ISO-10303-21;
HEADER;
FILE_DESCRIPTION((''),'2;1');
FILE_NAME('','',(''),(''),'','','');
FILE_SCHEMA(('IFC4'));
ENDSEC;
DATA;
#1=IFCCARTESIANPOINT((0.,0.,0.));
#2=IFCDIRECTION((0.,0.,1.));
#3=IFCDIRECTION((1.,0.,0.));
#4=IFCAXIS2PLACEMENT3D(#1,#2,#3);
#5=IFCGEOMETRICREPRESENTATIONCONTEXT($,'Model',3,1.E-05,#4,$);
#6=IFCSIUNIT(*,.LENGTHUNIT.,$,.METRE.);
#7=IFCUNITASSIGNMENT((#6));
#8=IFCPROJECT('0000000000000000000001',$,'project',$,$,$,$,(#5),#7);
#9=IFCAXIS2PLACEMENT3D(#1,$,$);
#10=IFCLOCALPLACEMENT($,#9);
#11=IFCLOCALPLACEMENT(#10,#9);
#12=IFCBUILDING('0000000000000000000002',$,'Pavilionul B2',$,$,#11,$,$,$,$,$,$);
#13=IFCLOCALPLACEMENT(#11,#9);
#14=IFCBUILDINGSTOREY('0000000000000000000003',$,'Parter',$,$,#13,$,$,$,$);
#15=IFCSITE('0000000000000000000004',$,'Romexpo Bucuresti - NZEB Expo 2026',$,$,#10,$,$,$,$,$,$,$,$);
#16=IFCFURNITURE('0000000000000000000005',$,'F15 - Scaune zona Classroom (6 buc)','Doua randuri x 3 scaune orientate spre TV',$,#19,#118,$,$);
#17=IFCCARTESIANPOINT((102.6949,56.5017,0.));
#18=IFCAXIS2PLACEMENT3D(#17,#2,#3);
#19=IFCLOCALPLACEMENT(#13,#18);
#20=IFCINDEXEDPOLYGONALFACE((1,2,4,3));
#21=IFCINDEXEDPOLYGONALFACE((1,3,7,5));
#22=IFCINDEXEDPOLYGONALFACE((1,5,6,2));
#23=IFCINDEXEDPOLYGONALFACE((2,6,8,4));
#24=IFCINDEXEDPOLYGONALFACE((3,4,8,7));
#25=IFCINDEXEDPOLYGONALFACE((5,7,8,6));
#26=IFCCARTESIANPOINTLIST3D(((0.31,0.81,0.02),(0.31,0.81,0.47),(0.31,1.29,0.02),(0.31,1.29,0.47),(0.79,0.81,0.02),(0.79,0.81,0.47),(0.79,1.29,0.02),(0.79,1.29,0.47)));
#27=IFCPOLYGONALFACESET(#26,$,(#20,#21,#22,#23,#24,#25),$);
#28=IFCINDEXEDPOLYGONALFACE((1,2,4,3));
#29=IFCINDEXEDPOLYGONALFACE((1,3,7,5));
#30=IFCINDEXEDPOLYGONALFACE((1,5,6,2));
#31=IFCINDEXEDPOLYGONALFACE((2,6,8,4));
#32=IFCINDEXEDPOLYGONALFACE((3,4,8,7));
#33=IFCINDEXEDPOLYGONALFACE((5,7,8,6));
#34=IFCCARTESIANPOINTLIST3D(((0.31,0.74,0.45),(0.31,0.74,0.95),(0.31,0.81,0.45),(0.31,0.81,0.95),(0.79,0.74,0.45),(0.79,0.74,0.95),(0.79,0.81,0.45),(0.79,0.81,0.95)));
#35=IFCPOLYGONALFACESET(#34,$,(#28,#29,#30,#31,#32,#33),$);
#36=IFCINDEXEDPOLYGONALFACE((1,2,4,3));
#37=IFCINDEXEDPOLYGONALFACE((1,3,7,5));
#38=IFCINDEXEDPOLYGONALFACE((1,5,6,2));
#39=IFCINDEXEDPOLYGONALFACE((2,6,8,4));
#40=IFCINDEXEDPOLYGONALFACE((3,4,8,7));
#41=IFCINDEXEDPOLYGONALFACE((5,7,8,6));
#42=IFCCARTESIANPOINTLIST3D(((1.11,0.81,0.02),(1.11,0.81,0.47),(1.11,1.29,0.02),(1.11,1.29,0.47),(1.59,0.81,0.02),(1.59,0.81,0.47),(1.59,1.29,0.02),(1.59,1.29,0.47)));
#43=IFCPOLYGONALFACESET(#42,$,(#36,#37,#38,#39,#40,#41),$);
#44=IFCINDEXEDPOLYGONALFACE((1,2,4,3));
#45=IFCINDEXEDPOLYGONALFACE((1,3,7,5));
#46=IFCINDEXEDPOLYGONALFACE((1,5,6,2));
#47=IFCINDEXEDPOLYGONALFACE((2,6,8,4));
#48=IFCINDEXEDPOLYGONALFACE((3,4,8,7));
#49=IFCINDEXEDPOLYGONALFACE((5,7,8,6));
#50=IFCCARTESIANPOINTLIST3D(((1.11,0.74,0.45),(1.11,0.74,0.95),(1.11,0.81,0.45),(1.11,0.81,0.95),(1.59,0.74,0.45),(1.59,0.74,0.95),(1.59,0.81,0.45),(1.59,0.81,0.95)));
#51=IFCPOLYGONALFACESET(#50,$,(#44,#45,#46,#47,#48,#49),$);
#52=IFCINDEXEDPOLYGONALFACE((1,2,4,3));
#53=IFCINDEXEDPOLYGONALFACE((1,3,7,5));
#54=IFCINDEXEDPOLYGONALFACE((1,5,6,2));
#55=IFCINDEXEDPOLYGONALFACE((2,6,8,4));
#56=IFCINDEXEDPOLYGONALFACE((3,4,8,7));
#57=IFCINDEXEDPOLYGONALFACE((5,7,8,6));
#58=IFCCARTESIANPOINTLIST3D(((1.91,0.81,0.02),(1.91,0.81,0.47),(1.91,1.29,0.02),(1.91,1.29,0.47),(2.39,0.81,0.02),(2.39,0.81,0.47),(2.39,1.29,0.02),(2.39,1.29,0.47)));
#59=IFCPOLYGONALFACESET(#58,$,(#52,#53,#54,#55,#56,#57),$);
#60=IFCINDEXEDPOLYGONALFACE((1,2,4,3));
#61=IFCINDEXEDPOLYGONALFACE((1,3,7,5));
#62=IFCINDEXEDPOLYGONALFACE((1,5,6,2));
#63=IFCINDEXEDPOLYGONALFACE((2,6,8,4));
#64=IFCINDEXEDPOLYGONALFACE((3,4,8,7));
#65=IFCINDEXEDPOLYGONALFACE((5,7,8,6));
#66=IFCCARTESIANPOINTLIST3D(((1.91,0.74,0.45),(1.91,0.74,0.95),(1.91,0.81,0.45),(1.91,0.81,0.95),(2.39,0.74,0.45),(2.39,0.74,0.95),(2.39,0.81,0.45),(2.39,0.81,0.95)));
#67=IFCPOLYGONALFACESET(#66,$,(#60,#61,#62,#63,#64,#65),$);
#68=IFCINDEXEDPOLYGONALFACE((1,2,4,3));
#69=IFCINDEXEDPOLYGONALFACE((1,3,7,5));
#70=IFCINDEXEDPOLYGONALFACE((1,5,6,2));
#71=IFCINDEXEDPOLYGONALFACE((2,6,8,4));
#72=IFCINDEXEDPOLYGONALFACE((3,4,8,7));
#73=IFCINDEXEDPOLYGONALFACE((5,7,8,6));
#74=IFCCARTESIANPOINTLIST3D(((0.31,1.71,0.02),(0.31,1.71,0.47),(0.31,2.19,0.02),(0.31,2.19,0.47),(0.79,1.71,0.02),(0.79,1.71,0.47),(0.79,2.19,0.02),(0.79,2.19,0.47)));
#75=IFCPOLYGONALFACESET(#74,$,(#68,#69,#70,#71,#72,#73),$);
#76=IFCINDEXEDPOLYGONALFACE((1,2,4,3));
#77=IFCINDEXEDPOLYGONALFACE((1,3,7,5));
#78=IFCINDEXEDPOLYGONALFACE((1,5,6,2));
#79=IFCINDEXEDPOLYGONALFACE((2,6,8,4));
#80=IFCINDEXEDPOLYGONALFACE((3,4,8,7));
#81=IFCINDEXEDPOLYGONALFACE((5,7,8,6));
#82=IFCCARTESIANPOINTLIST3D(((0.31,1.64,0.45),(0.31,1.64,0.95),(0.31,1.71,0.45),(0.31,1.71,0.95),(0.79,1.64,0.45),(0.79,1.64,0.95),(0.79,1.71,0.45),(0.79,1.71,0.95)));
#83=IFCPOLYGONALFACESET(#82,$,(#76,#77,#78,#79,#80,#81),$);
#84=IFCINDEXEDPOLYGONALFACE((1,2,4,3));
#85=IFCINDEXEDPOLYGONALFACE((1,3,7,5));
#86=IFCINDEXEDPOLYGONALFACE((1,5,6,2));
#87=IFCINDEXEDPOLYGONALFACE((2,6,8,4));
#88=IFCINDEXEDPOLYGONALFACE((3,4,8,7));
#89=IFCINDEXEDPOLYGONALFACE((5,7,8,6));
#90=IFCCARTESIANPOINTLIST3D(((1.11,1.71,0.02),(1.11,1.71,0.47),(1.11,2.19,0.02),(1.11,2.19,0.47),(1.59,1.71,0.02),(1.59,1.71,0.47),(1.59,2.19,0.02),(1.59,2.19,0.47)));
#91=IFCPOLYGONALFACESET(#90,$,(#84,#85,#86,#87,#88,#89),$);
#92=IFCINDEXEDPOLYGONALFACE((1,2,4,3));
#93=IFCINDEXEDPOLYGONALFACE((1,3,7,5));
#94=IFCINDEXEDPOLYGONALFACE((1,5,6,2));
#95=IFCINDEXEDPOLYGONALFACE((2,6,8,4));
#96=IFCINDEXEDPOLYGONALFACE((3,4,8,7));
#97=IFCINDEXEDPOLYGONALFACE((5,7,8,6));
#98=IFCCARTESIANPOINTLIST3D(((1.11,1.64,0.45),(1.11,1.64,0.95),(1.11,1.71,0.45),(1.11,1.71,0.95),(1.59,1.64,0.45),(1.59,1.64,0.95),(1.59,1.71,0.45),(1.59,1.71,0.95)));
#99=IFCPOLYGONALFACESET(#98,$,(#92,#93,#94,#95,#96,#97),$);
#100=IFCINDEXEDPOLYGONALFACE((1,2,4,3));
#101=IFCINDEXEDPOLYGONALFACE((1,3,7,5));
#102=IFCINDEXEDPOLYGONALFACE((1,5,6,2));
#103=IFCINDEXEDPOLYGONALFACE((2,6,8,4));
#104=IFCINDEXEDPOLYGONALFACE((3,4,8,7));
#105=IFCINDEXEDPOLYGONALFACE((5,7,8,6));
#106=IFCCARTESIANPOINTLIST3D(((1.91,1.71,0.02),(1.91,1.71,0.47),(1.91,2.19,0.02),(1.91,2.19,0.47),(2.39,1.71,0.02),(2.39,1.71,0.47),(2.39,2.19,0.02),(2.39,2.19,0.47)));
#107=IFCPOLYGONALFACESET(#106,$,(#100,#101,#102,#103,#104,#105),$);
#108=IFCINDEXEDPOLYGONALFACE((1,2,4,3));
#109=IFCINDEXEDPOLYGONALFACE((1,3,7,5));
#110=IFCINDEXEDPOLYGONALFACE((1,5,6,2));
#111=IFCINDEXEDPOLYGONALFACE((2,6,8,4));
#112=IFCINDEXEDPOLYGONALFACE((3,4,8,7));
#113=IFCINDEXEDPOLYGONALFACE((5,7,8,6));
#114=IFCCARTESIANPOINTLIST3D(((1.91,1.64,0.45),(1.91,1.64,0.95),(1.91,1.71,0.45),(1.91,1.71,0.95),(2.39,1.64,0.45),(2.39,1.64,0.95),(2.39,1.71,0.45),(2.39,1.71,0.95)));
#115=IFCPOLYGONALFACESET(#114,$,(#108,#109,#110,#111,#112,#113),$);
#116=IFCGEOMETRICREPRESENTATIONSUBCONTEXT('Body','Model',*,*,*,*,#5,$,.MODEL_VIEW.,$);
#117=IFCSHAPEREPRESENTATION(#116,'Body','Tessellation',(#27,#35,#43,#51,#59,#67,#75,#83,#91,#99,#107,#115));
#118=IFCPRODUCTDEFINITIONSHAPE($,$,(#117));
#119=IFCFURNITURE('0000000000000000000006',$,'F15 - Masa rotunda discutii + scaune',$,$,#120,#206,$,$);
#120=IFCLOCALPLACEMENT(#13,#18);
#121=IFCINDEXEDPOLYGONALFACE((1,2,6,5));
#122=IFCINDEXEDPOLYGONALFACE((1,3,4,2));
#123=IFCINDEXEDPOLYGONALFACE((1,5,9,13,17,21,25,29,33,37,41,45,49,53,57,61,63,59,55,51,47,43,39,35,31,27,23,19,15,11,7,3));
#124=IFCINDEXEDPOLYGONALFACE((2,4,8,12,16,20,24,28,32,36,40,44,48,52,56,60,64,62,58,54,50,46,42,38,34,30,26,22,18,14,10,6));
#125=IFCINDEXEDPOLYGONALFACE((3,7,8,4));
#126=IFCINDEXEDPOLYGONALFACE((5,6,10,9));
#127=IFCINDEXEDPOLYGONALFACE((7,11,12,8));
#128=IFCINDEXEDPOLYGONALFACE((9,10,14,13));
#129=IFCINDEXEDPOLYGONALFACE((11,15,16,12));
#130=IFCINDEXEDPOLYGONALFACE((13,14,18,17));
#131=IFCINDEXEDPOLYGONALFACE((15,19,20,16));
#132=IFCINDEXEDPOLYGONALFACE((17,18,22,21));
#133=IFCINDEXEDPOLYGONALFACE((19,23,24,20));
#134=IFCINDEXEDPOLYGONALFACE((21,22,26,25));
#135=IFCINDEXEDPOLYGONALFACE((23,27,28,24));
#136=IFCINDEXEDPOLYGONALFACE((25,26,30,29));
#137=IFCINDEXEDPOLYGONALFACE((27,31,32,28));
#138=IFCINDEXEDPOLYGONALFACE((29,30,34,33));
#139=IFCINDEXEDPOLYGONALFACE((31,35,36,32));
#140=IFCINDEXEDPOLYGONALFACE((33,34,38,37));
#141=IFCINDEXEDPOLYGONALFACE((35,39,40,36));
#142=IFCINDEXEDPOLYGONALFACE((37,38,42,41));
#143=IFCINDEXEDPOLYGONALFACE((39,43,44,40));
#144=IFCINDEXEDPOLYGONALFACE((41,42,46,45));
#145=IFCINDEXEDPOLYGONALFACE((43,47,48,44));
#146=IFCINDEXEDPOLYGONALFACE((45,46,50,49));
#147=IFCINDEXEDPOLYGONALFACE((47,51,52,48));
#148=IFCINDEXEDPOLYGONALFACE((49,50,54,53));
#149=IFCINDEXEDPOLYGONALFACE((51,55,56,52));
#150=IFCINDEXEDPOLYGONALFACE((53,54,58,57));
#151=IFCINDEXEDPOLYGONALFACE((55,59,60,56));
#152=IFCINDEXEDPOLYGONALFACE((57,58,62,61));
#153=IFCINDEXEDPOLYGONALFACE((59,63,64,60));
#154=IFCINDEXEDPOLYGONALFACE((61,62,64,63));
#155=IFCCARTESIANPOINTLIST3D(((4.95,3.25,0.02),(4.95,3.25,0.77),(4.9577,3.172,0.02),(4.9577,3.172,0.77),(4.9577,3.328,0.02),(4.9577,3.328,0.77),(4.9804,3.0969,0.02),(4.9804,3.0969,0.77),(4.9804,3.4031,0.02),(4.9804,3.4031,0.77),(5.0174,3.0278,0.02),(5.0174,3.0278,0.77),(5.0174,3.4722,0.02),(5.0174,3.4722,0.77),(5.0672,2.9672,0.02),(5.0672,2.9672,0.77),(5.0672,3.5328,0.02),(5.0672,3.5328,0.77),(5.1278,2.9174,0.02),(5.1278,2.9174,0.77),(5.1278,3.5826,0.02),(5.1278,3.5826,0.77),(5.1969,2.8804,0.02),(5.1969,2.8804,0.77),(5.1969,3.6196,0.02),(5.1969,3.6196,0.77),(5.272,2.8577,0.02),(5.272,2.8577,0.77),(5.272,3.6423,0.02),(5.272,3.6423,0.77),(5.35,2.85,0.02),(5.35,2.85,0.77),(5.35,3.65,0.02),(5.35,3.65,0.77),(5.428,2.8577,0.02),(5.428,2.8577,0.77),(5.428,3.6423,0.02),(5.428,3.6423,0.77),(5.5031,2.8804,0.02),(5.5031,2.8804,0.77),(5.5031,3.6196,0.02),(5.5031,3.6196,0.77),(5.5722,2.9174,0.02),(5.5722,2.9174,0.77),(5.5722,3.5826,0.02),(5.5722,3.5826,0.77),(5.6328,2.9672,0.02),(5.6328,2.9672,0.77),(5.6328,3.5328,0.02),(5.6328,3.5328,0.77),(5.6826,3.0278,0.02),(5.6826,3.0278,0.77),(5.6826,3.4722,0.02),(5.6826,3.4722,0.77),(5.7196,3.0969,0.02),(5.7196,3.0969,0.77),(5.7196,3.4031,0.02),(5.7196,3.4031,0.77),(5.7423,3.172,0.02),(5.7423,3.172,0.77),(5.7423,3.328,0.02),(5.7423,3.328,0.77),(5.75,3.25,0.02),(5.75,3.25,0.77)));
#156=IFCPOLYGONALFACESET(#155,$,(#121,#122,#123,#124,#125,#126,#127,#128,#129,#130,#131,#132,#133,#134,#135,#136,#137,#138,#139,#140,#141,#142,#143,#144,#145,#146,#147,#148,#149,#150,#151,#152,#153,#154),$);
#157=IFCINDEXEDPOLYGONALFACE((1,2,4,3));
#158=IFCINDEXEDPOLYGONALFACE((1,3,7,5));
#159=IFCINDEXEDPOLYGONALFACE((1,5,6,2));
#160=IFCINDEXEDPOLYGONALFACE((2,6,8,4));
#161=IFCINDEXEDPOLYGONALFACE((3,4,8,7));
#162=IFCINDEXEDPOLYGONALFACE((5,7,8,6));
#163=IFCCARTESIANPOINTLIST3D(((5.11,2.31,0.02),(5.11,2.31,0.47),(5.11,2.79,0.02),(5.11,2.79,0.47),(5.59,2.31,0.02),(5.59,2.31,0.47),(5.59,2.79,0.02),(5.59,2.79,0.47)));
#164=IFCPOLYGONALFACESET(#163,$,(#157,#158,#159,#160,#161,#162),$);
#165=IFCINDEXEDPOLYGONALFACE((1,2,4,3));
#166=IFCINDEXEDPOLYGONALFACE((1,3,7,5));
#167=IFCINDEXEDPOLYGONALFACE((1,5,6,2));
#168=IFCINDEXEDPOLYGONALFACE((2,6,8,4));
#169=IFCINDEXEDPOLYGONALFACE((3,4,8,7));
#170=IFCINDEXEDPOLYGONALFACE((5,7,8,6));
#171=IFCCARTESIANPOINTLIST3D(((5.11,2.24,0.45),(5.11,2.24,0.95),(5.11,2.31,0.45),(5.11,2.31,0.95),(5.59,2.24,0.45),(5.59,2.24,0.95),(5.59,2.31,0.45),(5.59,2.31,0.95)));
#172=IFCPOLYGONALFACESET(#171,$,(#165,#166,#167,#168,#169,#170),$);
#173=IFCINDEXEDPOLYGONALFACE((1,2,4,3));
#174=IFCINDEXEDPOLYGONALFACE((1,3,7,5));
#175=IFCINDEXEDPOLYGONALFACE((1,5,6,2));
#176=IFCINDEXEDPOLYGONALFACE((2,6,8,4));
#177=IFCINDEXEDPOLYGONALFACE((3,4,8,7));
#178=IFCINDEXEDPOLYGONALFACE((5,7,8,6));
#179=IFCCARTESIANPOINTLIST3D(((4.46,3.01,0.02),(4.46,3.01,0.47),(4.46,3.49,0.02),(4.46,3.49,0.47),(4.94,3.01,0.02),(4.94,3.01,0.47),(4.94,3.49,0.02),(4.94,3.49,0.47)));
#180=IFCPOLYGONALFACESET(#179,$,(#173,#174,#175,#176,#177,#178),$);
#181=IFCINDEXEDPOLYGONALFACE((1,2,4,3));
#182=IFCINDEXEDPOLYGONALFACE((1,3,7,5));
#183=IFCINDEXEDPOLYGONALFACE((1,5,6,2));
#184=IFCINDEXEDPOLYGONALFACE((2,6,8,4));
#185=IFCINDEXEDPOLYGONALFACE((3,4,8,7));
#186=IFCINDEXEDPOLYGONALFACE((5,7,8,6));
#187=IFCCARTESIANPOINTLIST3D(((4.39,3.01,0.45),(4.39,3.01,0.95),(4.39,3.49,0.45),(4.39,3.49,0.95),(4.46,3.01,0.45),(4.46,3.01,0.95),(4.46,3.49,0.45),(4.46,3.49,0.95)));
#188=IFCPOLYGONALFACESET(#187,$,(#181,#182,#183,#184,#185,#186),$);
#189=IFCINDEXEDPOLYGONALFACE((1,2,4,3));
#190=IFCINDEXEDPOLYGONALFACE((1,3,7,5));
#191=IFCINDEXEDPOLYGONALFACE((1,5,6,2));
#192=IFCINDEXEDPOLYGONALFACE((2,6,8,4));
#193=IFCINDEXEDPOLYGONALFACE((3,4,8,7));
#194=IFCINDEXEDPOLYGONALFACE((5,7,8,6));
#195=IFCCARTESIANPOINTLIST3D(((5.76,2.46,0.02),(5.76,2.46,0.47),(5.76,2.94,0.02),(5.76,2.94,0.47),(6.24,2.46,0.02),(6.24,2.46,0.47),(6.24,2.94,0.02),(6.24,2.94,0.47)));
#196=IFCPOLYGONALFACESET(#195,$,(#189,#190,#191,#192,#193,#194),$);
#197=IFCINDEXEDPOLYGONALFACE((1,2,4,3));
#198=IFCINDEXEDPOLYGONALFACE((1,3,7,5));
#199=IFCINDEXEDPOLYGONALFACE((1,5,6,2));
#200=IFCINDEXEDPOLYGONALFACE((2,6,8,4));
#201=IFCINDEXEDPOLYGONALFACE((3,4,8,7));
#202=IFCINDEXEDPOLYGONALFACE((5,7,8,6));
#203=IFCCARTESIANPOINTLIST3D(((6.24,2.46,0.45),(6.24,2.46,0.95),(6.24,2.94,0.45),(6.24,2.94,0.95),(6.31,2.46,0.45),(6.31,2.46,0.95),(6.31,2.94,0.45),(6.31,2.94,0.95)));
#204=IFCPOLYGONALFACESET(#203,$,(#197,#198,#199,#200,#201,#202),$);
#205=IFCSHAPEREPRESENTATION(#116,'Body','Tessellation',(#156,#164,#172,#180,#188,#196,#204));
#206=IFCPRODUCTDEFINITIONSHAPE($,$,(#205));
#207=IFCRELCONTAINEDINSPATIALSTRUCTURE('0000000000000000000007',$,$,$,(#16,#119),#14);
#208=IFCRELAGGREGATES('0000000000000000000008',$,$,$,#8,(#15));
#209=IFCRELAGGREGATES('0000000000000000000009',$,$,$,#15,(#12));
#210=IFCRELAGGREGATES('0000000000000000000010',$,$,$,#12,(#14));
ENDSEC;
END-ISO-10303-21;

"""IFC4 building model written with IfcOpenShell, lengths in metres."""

from ifc_helpers import new_model, si_unit, frame, frame_2d, origin, origin_with_axes, place, context, subcontext, project, spatial, rectangle, circle, extrude, element, save


model = new_model("IFC4")

# Units and contexts
model_context = context("Model", 3, precision=1e-05, world=origin_with_axes())
body_context = subcontext(model_context, "Body", "Model", "MODEL_VIEW")
ifc_project = project(units=[si_unit("LENGTHUNIT", "METRE")], contexts=[model_context])

# Site, building, storey
site_placement = place(None, origin())
site = spatial("IfcSite", under=ifc_project, at=site_placement, Name="Romexpo Bucuresti - NZEB Expo 2026")
building_placement = place(site_placement, origin())
building = spatial("IfcBuilding", under=site, at=building_placement, Name="Pavilionul B2")
storey_placement = place(building_placement, origin())
storey = spatial("IfcBuildingStorey", under=building, at=storey_placement, Name="Parter")

# Furniture
furniture_1_placement = place(storey_placement, frame((102.6949, 56.5017, 0.0), z_axis=(0.0, 0.0, 1.0), x_axis=(1.0, 0.0, 0.0)))
element("IfcFurniture", 1, at=furniture_1_placement, inside=storey, Name="F15 - Scaune zona Classroom (6 buc)", Description="Doua randuri x 3 scaune orientate spre TV", context=body_context, shape_type="SweptSolid", body=[
    extrude(rectangle(XDim=0.48, YDim=0.48, at=frame_2d((0.55, 1.05))), frame((0.0, 0.0, 0.02)), (0.0, 0.0, 1.0), 0.45),
    extrude(rectangle(XDim=0.48, YDim=0.07, at=frame_2d((0.55, 0.775))), frame((0.0, 0.0, 0.45)), (0.0, 0.0, 1.0), 0.5),
    extrude(rectangle(XDim=0.48, YDim=0.48, at=frame_2d((1.35, 1.05))), frame((0.0, 0.0, 0.02)), (0.0, 0.0, 1.0), 0.45),
    extrude(rectangle(XDim=0.48, YDim=0.07, at=frame_2d((1.35, 0.775))), frame((0.0, 0.0, 0.45)), (0.0, 0.0, 1.0), 0.5),
    extrude(rectangle(XDim=0.48, YDim=0.48, at=frame_2d((2.15, 1.05))), frame((0.0, 0.0, 0.02)), (0.0, 0.0, 1.0), 0.45),
    extrude(rectangle(XDim=0.48, YDim=0.07, at=frame_2d((2.15, 0.775))), frame((0.0, 0.0, 0.45)), (0.0, 0.0, 1.0), 0.5),
    extrude(rectangle(XDim=0.48, YDim=0.48, at=frame_2d((0.55, 1.95))), frame((0.0, 0.0, 0.02)), (0.0, 0.0, 1.0), 0.45),
    extrude(rectangle(XDim=0.48, YDim=0.07, at=frame_2d((0.55, 1.675))), frame((0.0, 0.0, 0.45)), (0.0, 0.0, 1.0), 0.5),
    extrude(rectangle(XDim=0.48, YDim=0.48, at=frame_2d((1.35, 1.95))), frame((0.0, 0.0, 0.02)), (0.0, 0.0, 1.0), 0.45),
    extrude(rectangle(XDim=0.48, YDim=0.07, at=frame_2d((1.35, 1.675))), frame((0.0, 0.0, 0.45)), (0.0, 0.0, 1.0), 0.5),
    extrude(rectangle(XDim=0.48, YDim=0.48, at=frame_2d((2.15, 1.95))), frame((0.0, 0.0, 0.02)), (0.0, 0.0, 1.0), 0.45),
    extrude(rectangle(XDim=0.48, YDim=0.07, at=frame_2d((2.15, 1.675))), frame((0.0, 0.0, 0.45)), (0.0, 0.0, 1.0), 0.5),
])
furniture_2_placement = place(storey_placement, frame((102.6949, 56.5017, 0.0), z_axis=(0.0, 0.0, 1.0), x_axis=(1.0, 0.0, 0.0)))
element("IfcFurniture", 2, at=furniture_2_placement, inside=storey, Name="F15 - Masa rotunda discutii + scaune", context=body_context, shape_type="SweptSolid", body=[
    extrude(circle(Radius=0.4, at=frame_2d((5.35, 3.25))), frame((0.0, 0.0, 0.02)), (0.0, 0.0, 1.0), 0.75),
    extrude(rectangle(XDim=0.48, YDim=0.48, at=frame_2d((5.35, 2.55))), frame((0.0, 0.0, 0.02)), (0.0, 0.0, 1.0), 0.45),
    extrude(rectangle(XDim=0.48, YDim=0.07, at=frame_2d((5.35, 2.275))), frame((0.0, 0.0, 0.45)), (0.0, 0.0, 1.0), 0.5),
    extrude(rectangle(XDim=0.48, YDim=0.48, at=frame_2d((4.7, 3.25))), frame((0.0, 0.0, 0.02)), (0.0, 0.0, 1.0), 0.45),
    extrude(rectangle(XDim=0.07, YDim=0.48, at=frame_2d((4.425, 3.25))), frame((0.0, 0.0, 0.45)), (0.0, 0.0, 1.0), 0.5),
    extrude(rectangle(XDim=0.48, YDim=0.48, at=frame_2d((6.0, 2.7))), frame((0.0, 0.0, 0.02)), (0.0, 0.0, 1.0), 0.45),
    extrude(rectangle(XDim=0.07, YDim=0.48, at=frame_2d((6.275, 2.7))), frame((0.0, 0.0, 0.45)), (0.0, 0.0, 1.0), 0.5),
])

save(model, "model.ifc")
